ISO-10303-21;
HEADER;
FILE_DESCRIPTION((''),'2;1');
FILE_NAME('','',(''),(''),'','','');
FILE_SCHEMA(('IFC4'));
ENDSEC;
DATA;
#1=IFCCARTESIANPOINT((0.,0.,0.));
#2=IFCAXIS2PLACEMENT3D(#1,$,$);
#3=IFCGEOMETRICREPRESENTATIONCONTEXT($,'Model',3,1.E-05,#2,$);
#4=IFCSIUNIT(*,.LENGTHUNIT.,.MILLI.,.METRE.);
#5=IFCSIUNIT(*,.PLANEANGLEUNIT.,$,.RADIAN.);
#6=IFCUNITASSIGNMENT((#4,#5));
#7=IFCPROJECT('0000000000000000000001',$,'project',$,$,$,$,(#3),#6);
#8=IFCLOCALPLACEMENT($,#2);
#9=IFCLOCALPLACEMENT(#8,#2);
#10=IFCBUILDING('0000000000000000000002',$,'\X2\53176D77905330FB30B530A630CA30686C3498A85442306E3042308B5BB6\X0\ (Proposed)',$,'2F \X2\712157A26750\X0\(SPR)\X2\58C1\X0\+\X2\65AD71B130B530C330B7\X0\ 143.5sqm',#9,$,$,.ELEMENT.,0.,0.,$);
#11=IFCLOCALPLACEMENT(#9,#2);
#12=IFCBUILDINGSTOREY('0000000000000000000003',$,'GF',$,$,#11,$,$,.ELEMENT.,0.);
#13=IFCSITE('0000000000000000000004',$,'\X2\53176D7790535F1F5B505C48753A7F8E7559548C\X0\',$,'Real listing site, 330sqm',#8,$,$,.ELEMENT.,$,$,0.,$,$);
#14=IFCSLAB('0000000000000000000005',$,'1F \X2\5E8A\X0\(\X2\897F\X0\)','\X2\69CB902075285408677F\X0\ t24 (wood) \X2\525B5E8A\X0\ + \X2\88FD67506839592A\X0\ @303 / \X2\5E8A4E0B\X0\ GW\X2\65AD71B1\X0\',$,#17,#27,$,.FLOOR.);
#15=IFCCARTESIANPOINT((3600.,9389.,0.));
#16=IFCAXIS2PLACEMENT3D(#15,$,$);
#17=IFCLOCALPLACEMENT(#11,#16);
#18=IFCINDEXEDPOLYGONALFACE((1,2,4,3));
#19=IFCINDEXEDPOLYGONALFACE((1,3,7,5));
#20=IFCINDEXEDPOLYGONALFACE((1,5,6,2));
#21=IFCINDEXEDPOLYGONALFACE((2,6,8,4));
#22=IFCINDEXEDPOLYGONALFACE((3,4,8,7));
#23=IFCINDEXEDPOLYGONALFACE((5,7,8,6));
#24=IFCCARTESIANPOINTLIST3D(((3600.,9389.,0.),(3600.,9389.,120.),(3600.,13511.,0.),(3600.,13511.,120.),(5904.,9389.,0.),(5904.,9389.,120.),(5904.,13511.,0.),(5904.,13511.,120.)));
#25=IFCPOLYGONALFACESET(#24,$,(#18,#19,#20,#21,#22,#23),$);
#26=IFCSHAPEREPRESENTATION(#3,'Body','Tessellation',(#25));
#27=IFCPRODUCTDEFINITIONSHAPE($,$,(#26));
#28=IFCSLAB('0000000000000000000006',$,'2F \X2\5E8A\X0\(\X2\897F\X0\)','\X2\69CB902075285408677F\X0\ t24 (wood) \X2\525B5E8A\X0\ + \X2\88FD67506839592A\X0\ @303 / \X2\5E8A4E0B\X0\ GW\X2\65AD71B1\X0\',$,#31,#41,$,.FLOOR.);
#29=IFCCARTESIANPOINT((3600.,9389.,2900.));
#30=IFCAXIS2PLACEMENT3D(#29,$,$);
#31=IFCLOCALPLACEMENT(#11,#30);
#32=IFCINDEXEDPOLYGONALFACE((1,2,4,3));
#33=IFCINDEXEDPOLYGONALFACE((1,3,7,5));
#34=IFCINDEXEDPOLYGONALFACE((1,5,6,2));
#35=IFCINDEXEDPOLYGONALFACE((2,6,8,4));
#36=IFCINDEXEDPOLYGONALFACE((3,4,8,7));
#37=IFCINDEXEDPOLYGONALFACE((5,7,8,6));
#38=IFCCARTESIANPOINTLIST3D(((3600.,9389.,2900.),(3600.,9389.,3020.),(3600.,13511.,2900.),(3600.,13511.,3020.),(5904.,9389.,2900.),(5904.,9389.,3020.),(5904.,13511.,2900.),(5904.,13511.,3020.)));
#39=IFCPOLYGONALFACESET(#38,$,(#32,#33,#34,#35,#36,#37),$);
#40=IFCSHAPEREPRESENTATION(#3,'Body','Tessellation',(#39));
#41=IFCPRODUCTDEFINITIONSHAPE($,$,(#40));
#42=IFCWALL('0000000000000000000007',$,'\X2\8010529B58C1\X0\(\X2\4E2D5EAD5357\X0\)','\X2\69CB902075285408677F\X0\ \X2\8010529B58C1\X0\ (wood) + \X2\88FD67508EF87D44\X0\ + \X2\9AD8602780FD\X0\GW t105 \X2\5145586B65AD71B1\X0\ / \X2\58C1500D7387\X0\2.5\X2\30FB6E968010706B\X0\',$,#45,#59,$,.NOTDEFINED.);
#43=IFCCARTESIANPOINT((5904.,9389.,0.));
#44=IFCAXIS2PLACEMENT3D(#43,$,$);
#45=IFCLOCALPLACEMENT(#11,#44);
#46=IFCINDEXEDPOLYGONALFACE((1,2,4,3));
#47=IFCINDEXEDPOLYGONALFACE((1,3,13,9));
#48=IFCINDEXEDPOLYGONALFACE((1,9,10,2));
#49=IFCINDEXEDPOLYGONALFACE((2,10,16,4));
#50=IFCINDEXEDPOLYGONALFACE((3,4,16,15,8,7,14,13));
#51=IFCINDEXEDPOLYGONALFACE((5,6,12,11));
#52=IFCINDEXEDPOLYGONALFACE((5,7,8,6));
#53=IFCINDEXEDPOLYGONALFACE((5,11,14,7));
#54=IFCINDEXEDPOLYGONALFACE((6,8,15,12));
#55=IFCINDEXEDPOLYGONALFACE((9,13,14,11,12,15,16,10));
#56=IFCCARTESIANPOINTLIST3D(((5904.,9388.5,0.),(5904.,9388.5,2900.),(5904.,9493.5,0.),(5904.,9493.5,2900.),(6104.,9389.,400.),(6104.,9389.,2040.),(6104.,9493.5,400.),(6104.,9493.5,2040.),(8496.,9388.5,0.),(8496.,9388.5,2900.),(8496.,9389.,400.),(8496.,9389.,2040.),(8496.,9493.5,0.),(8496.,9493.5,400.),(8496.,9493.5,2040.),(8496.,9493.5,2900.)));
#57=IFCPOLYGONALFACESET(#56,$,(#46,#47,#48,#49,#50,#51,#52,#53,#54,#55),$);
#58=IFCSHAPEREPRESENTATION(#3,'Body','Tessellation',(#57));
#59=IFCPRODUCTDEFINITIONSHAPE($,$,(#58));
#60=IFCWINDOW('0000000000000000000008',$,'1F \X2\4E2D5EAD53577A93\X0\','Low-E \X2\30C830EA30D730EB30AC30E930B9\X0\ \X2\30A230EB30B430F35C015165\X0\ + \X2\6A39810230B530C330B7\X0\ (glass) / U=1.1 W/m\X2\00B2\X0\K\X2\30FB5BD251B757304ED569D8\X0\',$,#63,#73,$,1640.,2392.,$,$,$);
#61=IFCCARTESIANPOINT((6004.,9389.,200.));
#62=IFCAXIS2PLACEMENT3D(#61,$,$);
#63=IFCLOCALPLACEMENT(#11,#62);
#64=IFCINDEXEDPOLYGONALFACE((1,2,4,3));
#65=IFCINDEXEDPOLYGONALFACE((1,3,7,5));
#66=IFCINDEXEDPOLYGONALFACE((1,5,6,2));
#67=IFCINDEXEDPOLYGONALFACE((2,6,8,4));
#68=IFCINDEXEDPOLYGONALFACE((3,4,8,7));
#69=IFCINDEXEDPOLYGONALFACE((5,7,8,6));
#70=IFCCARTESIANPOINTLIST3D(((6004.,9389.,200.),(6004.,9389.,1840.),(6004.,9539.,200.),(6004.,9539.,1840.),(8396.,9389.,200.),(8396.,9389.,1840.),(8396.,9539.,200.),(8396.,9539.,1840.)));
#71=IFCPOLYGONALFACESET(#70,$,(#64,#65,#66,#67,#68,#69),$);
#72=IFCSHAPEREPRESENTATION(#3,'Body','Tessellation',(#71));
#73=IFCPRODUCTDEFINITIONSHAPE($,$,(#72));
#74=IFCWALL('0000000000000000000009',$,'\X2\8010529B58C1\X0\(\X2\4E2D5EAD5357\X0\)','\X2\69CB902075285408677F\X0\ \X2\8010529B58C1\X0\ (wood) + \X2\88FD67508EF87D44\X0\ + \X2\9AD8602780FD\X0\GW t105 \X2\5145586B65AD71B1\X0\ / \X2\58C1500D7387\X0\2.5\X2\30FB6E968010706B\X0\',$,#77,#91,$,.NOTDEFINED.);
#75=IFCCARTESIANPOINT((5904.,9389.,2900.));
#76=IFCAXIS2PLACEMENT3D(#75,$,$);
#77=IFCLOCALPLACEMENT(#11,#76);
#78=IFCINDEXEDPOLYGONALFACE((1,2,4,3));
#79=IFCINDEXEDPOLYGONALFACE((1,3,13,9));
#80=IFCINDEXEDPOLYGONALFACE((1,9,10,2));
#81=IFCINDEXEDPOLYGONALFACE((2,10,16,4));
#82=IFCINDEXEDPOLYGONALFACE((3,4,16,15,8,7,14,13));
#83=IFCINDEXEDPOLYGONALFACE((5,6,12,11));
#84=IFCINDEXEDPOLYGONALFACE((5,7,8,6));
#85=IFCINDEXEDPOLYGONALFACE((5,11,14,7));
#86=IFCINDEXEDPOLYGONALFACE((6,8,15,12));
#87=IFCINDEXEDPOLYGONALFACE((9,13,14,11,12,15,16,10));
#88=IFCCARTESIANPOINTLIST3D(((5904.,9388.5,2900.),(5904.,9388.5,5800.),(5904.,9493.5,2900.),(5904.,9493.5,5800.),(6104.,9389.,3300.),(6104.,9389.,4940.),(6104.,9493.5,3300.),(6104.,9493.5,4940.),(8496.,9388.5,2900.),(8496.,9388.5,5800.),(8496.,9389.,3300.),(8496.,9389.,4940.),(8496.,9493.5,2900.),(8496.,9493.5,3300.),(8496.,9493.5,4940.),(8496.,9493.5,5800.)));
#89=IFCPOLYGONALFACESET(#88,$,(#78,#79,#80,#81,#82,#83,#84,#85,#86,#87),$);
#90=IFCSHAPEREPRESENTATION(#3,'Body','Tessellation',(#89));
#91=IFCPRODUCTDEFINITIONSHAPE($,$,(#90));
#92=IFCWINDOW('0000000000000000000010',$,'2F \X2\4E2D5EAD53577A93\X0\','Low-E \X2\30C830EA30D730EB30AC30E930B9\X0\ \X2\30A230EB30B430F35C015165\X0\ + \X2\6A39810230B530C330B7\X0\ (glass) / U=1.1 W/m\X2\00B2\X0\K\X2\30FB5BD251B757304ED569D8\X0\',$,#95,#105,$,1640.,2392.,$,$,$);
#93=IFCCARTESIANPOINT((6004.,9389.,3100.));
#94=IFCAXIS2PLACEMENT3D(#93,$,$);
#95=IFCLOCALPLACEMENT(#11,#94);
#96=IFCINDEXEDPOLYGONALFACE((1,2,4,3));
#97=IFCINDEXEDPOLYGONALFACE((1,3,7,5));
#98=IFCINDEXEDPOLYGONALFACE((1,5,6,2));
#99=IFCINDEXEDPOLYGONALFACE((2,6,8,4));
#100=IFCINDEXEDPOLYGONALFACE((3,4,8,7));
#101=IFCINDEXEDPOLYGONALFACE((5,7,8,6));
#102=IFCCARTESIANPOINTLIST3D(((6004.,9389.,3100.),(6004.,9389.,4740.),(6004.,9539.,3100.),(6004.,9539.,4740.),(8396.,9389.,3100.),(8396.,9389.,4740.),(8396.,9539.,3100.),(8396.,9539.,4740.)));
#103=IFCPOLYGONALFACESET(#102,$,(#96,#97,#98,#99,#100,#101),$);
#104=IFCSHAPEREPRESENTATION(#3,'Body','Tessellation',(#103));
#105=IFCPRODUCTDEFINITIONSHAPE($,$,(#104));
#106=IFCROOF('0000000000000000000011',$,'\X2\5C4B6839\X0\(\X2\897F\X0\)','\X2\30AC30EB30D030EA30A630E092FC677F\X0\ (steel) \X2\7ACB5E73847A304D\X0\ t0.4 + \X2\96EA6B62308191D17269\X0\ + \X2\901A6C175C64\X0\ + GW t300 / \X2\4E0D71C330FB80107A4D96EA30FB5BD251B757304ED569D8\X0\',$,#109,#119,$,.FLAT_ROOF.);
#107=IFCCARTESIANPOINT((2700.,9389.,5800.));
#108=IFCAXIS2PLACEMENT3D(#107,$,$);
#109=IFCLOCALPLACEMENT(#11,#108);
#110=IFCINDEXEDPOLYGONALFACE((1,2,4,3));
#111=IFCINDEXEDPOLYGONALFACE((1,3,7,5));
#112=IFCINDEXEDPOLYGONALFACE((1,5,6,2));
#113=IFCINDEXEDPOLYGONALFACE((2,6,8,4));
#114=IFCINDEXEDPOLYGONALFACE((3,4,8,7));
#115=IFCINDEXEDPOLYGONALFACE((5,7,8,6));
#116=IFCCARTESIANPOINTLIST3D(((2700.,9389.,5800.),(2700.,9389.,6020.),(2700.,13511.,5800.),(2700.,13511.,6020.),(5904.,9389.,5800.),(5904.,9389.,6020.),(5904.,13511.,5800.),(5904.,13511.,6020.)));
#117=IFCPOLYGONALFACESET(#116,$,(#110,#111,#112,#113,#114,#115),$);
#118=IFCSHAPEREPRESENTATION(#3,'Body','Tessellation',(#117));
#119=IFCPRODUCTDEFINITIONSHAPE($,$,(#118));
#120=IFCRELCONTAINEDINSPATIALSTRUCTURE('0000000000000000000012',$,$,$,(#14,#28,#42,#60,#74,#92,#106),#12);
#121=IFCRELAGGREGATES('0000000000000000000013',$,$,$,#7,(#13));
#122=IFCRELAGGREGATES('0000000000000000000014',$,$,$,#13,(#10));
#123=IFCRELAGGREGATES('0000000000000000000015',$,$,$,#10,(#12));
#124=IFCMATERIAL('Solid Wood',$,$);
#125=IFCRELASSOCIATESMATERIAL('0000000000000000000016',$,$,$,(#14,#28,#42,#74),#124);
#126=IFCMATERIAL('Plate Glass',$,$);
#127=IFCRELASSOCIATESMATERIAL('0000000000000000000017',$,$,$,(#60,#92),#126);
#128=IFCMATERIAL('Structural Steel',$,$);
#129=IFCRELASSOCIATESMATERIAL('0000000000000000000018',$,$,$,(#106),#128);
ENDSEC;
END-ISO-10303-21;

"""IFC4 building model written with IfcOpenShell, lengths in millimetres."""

from ifc_helpers import new_model, si_unit, frame, frame_2d, origin, place, context, project, spatial, rectangle, extrude, material, element, fill, save


model = new_model("IFC4")

# Units and contexts
model_context = context("Model", 3, precision=1e-05, world=origin())
ifc_project = project(units=[si_unit("LENGTHUNIT", "METRE", prefix="MILLI"), si_unit("PLANEANGLEUNIT", "RADIAN")], contexts=[model_context])

# Site, building, storey
site_placement = place(None, origin())
site = spatial("IfcSite", under=ifc_project, at=site_placement, Name="北海道弟子屈町美留和", ObjectType="Real listing site, 330sqm", CompositionType="ELEMENT", RefElevation=0.0)
building_placement = place(site_placement, origin())
building = spatial("IfcBuilding", under=site, at=building_placement, Name="北海道・サウナと水風呂のある家 (Proposed)", ObjectType="2F 無垢材(SPR)壁+断熱サッシ 143.5sqm", CompositionType="ELEMENT", ElevationOfRefHeight=0.0, ElevationOfTerrain=0.0)
storey_placement = place(building_placement, origin())
storey = spatial("IfcBuildingStorey", under=building, at=storey_placement, Name="GF", CompositionType="ELEMENT", Elevation=0.0)

# Shared definitions
ifc_material_1 = material(Name="Solid Wood")

# Slabs
slab_1_placement = place(storey_placement, frame((3600.0, 9389.0, 0.0)))
element("IfcSlab", 1, at=slab_1_placement, inside=storey, material=ifc_material_1, Name="1F 床(西)", Description="構造用合板 t24 (wood) 剛床 + 製材根太 @303 / 床下 GW断熱", PredefinedType="FLOOR", context=model_context, shape_type="SweptSolid", body=[
    extrude(rectangle(XDim=2304.0, YDim=4122.0, at=frame_2d((1152.0, 2061.0))), frame((3600.0, 9389.0, 0.0)), (0.0, 0.0, 1.0), 120.0),
])
slab_2_placement = place(storey_placement, frame((3600.0, 9389.0, 2900.0)))
element("IfcSlab", 2, at=slab_2_placement, inside=storey, material=ifc_material_1, Name="2F 床(西)", Description="構造用合板 t24 (wood) 剛床 + 製材根太 @303 / 床下 GW断熱", PredefinedType="FLOOR", context=model_context, shape_type="SweptSolid", body=[
    extrude(rectangle(XDim=2304.0, YDim=4122.0, at=frame_2d((1152.0, 2061.0))), frame((3600.0, 9389.0, 2900.0)), (0.0, 0.0, 1.0), 120.0),
])

# Wall, opening, window
wall_1_placement = place(storey_placement, frame((5904.0, 9389.0, 0.0)))
wall_1 = element("IfcWall", 3, at=wall_1_placement, inside=storey, material=ifc_material_1, Name="耐力壁(中庭南)", Description="構造用合板 耐力壁 (wood) + 製材軸組 + 高性能GW t105 充填断熱 / 壁倍率2.5・準耐火", PredefinedType="NOTDEFINED", context=model_context, shape_type="SweptSolid", body=[
    extrude(rectangle(XDim=2592.0, YDim=105.0, at=frame_2d((1296.0, 52.0))), frame((5904.0, 9389.0, 0.0)), (0.0, 0.0, 1.0), 2900.0),
])
opening_1_placement = place(storey_placement, frame((6004.0, 9389.0, 200.0)))
opening_1 = element("IfcOpeningElement", 4, at=opening_1_placement, cuts=wall_1, PredefinedType="NOTDEFINED", context=model_context, shape_type="SweptSolid", body=[
    extrude(rectangle(XDim=2392.0, YDim=150.0, at=frame_2d((1196.0, 75.0))), frame((6004.0, 9389.0, 200.0)), (0.0, 0.0, 1.0), 1640.0),
])
ifc_material_2 = material(Name="Plate Glass")
window_1_placement = place(storey_placement, frame((6004.0, 9389.0, 200.0)))
window_1 = element("IfcWindow", 5, at=window_1_placement, inside=storey, material=ifc_material_2, Name="1F 中庭南窓", Description="Low-E トリプルガラス アルゴン封入 + 樹脂サッシ (glass) / U=1.1 W/m²K・寒冷地仕様", OverallHeight=1640.0, OverallWidth=2392.0, context=model_context, shape_type="SweptSolid", body=[
    extrude(rectangle(XDim=2392.0, YDim=150.0, at=frame_2d((1196.0, 75.0))), frame((6004.0, 9389.0, 200.0)), (0.0, 0.0, 1.0), 1640.0),
])
fill(opening_1, window_1)

# Wall, opening, window
wall_2_placement = place(storey_placement, frame((5904.0, 9389.0, 2900.0)))
wall_2 = element("IfcWall", 6, at=wall_2_placement, inside=storey, material=ifc_material_1, Name="耐力壁(中庭南)", Description="構造用合板 耐力壁 (wood) + 製材軸組 + 高性能GW t105 充填断熱 / 壁倍率2.5・準耐火", PredefinedType="NOTDEFINED", context=model_context, shape_type="SweptSolid", body=[
    extrude(rectangle(XDim=2592.0, YDim=105.0, at=frame_2d((1296.0, 52.0))), frame((5904.0, 9389.0, 2900.0)), (0.0, 0.0, 1.0), 2900.0),
])
opening_2_placement = place(storey_placement, frame((6004.0, 9389.0, 3100.0)))
opening_2 = element("IfcOpeningElement", 7, at=opening_2_placement, cuts=wall_2, PredefinedType="NOTDEFINED", context=model_context, shape_type="SweptSolid", body=[
    extrude(rectangle(XDim=2392.0, YDim=150.0, at=frame_2d((1196.0, 75.0))), frame((6004.0, 9389.0, 3100.0)), (0.0, 0.0, 1.0), 1640.0),
])
window_2_placement = place(storey_placement, frame((6004.0, 9389.0, 3100.0)))
window_2 = element("IfcWindow", 8, at=window_2_placement, inside=storey, material=ifc_material_2, Name="2F 中庭南窓", Description="Low-E トリプルガラス アルゴン封入 + 樹脂サッシ (glass) / U=1.1 W/m²K・寒冷地仕様", OverallHeight=1640.0, OverallWidth=2392.0, context=model_context, shape_type="SweptSolid", body=[
    extrude(rectangle(XDim=2392.0, YDim=150.0, at=frame_2d((1196.0, 75.0))), frame((6004.0, 9389.0, 3100.0)), (0.0, 0.0, 1.0), 1640.0),
])
fill(opening_2, window_2)

# Roof
ifc_material_3 = material(Name="Structural Steel")
for number, where, name in (
    (9, (2700.0, 9389.0, 5800.0), "屋根(西)"),
):
    element("IfcRoof", number, at=place(storey_placement, frame(where)), inside=storey, material=ifc_material_3, Name=name, Description="ガルバリウム鋼板 (steel) 立平葺き t0.4 + 雪止め金物 + 通気層 + GW t300 / 不燃・耐積雪・寒冷地仕様", PredefinedType="FLAT_ROOF", context=model_context, shape_type="SweptSolid", body=[
        extrude(rectangle(XDim=3204.0, YDim=4122.0, at=frame_2d((1602.0, 2061.0))), frame((2700.0, 9389.0, 5800.0)), (0.0, 0.0, 1.0), 220.0),
    ])

save(model, "model.ifc")
